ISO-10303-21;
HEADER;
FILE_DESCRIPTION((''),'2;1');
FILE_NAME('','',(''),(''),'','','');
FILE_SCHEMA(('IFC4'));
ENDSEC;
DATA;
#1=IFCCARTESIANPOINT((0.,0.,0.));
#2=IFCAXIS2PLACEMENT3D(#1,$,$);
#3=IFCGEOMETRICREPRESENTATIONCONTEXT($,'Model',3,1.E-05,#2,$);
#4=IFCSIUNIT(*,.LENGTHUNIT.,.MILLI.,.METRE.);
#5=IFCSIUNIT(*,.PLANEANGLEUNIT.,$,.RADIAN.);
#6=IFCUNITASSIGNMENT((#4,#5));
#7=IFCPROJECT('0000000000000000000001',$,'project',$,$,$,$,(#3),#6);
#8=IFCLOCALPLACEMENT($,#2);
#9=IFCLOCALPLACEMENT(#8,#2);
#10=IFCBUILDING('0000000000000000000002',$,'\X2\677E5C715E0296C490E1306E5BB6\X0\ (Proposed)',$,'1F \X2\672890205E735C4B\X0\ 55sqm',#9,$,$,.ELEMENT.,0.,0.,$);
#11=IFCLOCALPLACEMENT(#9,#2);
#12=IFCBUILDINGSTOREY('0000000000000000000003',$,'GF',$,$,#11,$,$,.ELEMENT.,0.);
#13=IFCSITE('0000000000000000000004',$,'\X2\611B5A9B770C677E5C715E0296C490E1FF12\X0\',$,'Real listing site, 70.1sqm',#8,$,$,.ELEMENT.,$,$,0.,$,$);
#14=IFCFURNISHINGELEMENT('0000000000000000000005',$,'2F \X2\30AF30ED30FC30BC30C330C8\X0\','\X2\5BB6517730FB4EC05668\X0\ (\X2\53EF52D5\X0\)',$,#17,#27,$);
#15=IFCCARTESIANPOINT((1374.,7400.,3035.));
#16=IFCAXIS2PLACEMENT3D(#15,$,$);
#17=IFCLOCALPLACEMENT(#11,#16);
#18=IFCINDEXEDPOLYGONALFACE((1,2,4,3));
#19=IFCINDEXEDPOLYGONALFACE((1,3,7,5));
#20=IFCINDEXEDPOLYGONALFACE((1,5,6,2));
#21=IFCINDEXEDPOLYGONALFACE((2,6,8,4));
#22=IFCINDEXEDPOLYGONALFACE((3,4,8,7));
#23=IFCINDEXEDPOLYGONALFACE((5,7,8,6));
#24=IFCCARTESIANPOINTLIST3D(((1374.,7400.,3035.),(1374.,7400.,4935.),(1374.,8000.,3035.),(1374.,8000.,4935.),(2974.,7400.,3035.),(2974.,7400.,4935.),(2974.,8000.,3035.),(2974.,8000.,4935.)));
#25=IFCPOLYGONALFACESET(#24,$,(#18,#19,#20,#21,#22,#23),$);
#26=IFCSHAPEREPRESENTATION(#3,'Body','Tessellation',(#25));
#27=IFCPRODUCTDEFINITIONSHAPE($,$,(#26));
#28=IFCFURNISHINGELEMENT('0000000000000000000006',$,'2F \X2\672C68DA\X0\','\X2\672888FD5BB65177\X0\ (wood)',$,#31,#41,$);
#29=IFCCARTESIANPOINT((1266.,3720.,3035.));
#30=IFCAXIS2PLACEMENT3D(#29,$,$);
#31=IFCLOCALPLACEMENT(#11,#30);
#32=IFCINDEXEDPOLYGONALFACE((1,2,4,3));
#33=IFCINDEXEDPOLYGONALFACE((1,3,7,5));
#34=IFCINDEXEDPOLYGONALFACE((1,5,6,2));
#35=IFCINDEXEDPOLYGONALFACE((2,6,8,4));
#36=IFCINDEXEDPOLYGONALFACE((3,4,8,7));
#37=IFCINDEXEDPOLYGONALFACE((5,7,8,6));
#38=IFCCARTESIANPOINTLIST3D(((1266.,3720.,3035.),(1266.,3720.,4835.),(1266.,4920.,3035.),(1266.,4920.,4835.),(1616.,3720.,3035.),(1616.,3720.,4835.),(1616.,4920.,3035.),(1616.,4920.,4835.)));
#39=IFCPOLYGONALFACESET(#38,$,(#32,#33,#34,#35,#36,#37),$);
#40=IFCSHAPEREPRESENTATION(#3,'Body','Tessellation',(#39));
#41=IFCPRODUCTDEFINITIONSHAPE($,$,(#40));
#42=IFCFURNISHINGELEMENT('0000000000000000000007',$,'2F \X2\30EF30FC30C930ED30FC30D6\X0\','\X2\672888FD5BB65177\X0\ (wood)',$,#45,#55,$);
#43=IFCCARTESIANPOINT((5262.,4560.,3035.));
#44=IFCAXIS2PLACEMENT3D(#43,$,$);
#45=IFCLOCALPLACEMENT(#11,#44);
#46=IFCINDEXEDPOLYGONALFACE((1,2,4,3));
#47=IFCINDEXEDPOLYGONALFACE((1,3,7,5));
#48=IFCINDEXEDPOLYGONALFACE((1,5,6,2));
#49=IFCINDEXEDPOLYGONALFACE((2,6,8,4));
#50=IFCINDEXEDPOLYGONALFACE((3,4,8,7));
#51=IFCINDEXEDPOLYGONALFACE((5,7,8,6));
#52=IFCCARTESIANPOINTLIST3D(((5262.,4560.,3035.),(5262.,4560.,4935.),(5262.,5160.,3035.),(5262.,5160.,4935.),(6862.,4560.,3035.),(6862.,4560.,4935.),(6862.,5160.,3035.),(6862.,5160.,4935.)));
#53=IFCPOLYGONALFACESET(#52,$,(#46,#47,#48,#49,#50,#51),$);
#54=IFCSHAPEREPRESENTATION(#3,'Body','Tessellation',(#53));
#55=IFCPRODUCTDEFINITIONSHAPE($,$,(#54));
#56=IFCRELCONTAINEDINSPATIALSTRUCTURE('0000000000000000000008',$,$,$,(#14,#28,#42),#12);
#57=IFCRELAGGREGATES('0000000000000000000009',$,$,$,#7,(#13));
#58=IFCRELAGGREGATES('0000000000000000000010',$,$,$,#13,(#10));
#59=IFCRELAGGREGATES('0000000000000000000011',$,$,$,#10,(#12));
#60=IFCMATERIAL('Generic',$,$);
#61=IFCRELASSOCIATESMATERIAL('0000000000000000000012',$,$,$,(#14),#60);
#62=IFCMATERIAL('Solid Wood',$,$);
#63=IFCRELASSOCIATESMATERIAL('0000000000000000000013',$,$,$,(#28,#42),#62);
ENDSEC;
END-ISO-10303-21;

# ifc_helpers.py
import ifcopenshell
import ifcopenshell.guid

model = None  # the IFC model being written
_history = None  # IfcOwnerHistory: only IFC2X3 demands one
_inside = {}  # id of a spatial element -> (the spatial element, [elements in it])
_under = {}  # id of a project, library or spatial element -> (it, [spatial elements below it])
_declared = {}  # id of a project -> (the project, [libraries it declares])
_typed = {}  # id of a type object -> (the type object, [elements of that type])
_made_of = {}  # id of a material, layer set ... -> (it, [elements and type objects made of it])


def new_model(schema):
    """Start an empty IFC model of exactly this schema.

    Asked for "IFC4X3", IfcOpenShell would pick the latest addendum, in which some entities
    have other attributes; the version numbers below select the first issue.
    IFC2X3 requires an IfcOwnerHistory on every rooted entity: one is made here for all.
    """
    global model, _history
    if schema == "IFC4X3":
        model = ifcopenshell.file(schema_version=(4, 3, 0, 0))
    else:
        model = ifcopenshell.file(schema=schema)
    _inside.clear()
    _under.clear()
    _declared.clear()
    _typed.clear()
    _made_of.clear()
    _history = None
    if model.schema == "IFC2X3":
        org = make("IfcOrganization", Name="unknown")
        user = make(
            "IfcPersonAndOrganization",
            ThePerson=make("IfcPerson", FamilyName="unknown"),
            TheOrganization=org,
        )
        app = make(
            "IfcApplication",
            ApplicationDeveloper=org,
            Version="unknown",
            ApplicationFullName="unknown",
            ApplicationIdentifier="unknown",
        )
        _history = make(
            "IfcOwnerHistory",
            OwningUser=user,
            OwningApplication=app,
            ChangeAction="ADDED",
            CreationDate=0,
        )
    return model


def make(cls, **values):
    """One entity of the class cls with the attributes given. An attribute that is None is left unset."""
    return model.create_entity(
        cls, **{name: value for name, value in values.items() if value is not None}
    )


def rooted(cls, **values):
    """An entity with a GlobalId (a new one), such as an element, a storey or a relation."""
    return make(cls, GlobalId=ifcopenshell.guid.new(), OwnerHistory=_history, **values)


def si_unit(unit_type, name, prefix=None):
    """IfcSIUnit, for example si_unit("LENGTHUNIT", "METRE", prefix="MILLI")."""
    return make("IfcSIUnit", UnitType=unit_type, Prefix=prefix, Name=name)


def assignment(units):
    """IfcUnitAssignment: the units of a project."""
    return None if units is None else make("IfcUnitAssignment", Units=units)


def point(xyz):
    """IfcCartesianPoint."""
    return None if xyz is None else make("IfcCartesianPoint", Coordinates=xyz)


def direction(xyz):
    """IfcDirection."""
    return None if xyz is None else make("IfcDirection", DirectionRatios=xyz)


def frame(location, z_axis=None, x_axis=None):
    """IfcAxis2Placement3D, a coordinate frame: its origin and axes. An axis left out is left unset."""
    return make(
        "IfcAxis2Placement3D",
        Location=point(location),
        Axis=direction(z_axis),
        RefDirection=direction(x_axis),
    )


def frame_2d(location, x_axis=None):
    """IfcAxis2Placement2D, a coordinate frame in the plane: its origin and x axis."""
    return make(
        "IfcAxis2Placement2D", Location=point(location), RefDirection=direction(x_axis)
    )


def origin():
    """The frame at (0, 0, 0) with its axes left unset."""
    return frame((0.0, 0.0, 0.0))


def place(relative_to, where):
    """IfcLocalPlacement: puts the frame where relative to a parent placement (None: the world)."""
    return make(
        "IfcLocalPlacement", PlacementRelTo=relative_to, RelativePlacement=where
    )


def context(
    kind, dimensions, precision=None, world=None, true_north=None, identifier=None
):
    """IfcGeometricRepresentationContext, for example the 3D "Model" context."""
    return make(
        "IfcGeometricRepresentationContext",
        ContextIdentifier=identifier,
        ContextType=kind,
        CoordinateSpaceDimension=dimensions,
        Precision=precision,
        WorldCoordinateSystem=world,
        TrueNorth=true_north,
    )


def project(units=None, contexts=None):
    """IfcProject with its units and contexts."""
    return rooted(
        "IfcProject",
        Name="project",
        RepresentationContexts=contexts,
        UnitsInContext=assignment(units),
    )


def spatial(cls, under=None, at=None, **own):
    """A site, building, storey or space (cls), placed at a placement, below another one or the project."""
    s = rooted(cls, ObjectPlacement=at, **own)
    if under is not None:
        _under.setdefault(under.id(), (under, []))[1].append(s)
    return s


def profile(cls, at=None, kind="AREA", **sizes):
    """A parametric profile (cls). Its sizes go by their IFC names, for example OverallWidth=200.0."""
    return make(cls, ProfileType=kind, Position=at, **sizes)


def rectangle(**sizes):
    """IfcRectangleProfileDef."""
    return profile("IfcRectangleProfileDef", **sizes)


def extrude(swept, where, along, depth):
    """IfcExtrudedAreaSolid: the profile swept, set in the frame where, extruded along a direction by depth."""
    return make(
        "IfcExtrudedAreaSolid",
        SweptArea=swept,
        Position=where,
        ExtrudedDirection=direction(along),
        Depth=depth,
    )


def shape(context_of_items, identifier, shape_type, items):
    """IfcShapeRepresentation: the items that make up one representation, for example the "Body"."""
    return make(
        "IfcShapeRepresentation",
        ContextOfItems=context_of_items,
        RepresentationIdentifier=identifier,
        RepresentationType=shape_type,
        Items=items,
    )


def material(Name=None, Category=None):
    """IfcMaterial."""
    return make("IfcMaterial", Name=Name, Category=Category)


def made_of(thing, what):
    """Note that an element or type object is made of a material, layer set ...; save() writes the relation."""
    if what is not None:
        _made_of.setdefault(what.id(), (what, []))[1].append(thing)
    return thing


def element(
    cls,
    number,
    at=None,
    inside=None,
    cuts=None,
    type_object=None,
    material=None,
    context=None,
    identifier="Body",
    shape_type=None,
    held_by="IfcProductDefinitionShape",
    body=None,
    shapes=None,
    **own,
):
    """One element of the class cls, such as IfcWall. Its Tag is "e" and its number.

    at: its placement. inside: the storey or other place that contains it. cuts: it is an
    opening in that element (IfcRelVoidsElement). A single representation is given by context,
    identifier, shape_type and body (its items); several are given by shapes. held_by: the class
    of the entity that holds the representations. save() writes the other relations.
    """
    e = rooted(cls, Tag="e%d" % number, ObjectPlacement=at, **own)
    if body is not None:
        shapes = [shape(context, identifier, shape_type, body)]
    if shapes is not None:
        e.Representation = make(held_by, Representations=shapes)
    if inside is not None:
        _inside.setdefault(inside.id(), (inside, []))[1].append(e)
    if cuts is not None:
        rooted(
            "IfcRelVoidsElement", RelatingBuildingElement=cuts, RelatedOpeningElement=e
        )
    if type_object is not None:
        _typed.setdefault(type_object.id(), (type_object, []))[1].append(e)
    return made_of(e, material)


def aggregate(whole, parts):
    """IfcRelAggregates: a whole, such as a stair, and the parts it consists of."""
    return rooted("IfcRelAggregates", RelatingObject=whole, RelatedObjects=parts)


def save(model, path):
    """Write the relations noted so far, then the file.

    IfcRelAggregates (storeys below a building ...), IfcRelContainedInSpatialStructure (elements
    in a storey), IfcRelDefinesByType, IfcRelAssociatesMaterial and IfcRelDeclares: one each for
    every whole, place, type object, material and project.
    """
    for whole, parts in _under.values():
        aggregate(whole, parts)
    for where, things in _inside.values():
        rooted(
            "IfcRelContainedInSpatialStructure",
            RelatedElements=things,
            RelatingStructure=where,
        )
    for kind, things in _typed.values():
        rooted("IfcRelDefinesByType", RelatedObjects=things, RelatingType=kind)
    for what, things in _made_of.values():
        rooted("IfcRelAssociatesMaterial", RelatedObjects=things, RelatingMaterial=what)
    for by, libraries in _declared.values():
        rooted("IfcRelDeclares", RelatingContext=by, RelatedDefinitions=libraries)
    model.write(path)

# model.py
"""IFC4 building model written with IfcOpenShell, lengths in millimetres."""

from ifc_helpers import new_model, si_unit, frame, frame_2d, origin, place, context, project, spatial, rectangle, extrude, material, element, save


model = new_model("IFC4")

# Units and contexts
model_context = context("Model", 3, precision=1e-05, world=origin())
ifc_project = project(units=[si_unit("LENGTHUNIT", "METRE", prefix="MILLI"), si_unit("PLANEANGLEUNIT", "RADIAN")], contexts=[model_context])

# Site, building, storey
site_placement = place(None, origin())
site = spatial("IfcSite", under=ifc_project, at=site_placement, Name="愛媛県松山市雄郡２", ObjectType="Real listing site, 70.1sqm", CompositionType="ELEMENT", RefElevation=0.0)
building_placement = place(site_placement, origin())
building = spatial("IfcBuilding", under=site, at=building_placement, Name="松山市雄郡の家 (Proposed)", ObjectType="1F 木造平屋 55sqm", CompositionType="ELEMENT", ElevationOfRefHeight=0.0, ElevationOfTerrain=0.0)
storey_placement = place(building_placement, origin())
storey = spatial("IfcBuildingStorey", under=building, at=storey_placement, Name="GF", CompositionType="ELEMENT", Elevation=0.0)

# Shared definitions
ifc_material_1 = material(Name="Solid Wood")

# Shared definitions
ifc_material_2 = material(Name="Generic")

# Furnishing elements
furnishing_1_placement = place(storey_placement, frame((1374.0, 7400.0, 3035.0)))
element("IfcFurnishingElement", 1, at=furnishing_1_placement, inside=storey, material=ifc_material_2, Name="2F クローゼット", Description="家具・什器 (可動)", context=model_context, shape_type="SweptSolid", body=[
    extrude(rectangle(XDim=1600.0, YDim=600.0, at=frame_2d((800.0, 300.0))), frame((1374.0, 7400.0, 3035.0)), (0.0, 0.0, 1.0), 1900.0),
])
furnishing_2_placement = place(storey_placement, frame((1266.0, 3720.0, 3035.0)))
element("IfcFurnishingElement", 2, at=furnishing_2_placement, inside=storey, material=ifc_material_1, Name="2F 本棚", Description="木製家具 (wood)", context=model_context, shape_type="SweptSolid", body=[
    extrude(rectangle(XDim=350.0, YDim=1200.0, at=frame_2d((175.0, 600.0))), frame((1266.0, 3720.0, 3035.0)), (0.0, 0.0, 1.0), 1800.0),
])
furnishing_3_placement = place(storey_placement, frame((5262.0, 4560.0, 3035.0)))
element("IfcFurnishingElement", 3, at=furnishing_3_placement, inside=storey, material=ifc_material_1, Name="2F ワードローブ", Description="木製家具 (wood)", context=model_context, shape_type="SweptSolid", body=[
    extrude(rectangle(XDim=1600.0, YDim=600.0, at=frame_2d((800.0, 300.0))), frame((5262.0, 4560.0, 3035.0)), (0.0, 0.0, 1.0), 1900.0),
])

save(model, "model.ifc")
